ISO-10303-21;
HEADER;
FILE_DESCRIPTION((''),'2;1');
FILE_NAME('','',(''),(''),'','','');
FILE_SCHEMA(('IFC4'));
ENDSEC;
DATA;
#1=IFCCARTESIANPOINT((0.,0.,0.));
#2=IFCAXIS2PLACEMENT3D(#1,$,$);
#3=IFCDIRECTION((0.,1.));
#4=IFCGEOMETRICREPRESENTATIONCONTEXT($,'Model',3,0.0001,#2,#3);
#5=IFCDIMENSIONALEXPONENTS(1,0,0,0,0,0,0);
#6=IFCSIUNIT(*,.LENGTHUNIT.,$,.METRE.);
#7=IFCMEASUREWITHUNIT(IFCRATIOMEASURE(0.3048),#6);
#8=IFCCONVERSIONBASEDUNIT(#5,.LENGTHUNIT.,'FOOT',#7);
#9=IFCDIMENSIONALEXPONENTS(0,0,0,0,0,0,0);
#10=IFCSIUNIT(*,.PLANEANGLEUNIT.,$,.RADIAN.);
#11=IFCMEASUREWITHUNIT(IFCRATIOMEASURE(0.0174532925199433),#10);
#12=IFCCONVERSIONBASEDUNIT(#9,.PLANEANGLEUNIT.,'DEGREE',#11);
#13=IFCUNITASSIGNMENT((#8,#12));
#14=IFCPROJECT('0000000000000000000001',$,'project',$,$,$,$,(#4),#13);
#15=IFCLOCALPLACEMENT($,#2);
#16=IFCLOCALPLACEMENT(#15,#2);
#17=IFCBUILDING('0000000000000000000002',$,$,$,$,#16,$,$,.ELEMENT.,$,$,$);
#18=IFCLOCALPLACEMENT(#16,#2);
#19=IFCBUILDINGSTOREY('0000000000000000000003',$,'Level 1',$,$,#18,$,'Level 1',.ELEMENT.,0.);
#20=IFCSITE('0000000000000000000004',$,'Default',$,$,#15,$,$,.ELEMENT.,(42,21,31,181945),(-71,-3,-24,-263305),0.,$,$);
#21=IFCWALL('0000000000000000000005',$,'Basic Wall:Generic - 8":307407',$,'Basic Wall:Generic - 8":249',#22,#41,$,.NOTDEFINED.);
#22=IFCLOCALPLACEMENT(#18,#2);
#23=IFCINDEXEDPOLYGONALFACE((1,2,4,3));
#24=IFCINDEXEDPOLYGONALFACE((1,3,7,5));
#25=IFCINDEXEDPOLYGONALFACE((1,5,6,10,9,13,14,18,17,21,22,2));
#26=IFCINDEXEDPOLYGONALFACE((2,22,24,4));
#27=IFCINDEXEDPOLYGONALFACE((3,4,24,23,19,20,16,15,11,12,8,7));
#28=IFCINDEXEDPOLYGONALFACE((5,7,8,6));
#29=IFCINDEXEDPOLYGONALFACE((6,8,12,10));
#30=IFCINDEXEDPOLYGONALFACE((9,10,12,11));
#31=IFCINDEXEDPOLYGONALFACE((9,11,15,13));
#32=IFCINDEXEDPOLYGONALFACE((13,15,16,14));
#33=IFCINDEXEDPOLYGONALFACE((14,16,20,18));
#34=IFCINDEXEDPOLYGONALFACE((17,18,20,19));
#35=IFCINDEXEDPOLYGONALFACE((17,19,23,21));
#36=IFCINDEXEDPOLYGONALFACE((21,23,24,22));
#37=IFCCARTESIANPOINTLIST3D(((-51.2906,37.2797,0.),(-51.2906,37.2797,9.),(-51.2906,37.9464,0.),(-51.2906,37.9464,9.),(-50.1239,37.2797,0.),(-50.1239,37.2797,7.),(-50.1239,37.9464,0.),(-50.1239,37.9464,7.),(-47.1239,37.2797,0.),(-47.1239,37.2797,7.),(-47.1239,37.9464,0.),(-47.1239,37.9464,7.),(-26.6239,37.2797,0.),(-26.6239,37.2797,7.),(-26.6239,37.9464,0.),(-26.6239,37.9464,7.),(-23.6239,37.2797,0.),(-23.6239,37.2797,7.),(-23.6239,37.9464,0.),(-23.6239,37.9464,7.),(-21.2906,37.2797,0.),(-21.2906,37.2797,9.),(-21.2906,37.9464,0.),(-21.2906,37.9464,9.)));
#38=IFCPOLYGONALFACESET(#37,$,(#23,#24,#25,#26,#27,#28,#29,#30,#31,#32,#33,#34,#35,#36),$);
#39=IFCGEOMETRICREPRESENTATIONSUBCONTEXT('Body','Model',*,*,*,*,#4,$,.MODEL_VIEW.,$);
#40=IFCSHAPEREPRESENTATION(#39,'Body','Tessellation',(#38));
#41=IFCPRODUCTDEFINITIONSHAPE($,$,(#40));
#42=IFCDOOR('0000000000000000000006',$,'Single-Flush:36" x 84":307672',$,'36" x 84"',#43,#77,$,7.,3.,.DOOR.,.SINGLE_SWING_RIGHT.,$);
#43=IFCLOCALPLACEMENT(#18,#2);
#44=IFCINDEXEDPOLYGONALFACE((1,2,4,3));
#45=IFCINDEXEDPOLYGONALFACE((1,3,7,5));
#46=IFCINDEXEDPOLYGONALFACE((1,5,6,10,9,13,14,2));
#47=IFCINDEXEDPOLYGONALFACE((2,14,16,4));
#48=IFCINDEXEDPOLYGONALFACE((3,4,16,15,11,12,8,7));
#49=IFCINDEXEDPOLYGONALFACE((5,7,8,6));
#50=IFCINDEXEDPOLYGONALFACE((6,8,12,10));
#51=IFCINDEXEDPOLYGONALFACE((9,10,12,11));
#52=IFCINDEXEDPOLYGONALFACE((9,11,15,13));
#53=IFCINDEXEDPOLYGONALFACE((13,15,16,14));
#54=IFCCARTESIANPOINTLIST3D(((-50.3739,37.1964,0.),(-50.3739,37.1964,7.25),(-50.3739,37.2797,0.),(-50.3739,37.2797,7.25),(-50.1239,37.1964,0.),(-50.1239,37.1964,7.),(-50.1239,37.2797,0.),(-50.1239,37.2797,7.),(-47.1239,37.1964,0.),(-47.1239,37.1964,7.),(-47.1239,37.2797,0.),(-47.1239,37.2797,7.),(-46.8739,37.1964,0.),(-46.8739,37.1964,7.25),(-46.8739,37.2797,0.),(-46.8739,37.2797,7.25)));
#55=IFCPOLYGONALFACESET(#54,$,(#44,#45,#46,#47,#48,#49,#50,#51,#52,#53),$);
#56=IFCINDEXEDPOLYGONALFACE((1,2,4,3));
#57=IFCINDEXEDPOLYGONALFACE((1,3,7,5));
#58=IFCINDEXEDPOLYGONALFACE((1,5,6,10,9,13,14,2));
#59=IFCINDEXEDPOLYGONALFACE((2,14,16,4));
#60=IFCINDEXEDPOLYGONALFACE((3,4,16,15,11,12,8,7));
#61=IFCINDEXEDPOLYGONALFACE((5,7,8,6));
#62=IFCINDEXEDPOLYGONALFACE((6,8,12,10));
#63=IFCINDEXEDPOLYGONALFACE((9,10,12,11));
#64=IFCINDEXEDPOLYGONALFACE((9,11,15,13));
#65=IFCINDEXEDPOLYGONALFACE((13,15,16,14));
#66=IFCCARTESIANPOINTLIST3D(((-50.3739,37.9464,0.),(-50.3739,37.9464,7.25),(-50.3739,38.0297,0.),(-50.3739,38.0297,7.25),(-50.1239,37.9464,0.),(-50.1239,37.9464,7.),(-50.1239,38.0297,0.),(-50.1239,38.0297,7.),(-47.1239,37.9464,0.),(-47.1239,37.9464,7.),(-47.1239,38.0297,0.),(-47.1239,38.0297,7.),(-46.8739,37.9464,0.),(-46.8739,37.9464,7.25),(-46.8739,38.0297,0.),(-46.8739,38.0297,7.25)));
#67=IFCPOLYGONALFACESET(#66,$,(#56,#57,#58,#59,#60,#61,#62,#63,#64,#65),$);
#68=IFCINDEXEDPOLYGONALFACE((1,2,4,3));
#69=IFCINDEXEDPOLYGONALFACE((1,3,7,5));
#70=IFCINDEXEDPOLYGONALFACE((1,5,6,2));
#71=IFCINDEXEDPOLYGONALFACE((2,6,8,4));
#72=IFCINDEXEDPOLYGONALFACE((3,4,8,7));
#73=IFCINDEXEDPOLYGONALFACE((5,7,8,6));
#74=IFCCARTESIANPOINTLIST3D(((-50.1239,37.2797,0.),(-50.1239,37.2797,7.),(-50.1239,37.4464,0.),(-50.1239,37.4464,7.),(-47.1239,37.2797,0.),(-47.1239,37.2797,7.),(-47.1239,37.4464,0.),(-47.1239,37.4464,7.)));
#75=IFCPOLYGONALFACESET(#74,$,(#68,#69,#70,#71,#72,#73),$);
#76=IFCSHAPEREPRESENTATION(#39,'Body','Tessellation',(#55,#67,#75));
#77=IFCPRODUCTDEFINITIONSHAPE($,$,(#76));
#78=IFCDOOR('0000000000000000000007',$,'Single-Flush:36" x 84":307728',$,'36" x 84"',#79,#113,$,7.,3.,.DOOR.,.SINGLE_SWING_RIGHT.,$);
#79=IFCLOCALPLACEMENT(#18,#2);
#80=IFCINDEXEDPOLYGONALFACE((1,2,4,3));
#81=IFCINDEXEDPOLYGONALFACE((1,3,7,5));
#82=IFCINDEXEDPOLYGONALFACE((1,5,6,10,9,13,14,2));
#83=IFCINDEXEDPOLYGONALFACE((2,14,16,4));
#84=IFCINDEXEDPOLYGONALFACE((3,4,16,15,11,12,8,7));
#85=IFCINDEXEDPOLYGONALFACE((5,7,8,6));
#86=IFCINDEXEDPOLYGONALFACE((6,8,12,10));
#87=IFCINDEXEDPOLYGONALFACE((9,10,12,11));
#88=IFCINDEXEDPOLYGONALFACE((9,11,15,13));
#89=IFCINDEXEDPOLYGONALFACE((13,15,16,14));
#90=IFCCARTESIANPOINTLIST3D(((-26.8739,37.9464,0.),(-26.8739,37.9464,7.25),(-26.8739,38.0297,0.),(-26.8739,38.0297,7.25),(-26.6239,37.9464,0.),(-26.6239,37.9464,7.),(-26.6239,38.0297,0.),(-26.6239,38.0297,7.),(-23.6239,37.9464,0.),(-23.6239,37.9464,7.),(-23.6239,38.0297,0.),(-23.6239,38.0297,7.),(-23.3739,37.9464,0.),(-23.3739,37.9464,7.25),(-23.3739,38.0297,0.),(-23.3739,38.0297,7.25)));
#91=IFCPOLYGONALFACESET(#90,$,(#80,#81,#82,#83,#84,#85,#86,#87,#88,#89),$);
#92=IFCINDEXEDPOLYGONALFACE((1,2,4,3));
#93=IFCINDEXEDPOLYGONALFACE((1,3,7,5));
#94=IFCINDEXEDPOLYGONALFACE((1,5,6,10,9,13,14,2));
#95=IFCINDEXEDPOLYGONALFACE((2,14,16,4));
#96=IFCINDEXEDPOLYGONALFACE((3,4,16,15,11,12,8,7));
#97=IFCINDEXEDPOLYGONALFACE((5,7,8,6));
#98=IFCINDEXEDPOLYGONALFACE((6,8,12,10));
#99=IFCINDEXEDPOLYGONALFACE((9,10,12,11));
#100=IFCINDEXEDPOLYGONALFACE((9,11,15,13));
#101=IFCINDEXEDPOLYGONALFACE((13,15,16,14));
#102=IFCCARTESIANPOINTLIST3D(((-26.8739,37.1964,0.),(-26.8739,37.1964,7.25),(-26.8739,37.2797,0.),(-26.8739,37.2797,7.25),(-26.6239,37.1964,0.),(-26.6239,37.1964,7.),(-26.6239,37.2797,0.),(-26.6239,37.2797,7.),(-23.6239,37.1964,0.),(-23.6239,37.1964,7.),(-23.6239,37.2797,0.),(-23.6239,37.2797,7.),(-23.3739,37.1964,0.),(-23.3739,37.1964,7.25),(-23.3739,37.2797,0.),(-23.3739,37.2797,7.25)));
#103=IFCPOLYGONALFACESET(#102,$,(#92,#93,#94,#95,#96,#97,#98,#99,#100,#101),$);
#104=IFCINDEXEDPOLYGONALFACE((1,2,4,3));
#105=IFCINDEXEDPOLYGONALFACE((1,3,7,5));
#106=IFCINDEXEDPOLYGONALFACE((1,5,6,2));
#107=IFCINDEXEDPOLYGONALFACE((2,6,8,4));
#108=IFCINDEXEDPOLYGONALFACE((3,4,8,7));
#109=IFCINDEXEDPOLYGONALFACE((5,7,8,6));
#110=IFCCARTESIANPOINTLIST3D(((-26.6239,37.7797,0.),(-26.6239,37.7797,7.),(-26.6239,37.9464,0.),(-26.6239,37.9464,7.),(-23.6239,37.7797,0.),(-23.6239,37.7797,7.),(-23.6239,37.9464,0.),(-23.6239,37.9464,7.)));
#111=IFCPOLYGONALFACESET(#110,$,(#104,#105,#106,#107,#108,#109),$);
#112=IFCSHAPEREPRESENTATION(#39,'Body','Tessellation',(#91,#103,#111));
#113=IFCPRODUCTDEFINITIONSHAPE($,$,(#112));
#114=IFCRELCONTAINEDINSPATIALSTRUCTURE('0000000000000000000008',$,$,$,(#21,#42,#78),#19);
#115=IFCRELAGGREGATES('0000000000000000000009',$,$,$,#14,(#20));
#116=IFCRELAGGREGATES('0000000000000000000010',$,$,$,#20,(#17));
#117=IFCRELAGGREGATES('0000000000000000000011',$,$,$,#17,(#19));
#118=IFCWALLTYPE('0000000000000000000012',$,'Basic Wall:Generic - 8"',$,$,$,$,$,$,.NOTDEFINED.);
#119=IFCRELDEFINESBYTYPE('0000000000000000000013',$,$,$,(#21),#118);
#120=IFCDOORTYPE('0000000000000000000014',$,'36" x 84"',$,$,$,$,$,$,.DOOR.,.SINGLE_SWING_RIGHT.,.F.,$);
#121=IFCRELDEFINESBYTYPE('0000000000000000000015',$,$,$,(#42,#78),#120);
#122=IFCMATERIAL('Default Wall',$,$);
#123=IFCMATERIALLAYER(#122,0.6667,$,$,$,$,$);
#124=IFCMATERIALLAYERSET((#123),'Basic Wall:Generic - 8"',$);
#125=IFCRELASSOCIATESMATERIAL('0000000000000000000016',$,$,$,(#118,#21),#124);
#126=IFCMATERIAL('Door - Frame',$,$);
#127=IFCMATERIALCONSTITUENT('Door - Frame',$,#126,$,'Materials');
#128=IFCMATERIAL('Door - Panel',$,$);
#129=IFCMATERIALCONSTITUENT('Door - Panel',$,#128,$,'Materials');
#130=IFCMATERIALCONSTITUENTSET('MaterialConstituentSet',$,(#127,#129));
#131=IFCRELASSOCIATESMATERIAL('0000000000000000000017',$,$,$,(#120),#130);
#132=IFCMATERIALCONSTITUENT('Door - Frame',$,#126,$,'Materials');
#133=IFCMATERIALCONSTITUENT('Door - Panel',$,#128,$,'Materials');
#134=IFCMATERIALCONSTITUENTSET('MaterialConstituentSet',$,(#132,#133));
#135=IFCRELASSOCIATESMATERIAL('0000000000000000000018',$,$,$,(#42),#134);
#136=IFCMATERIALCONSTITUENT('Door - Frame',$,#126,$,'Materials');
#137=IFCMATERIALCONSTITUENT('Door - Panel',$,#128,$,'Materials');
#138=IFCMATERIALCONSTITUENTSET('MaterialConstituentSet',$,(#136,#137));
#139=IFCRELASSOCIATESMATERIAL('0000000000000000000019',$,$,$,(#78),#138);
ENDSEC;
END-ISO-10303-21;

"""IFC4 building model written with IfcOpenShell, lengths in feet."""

from ifc_helpers import new_model, entity, si_unit, converted_unit, direction, frame, frame_2d, origin, place, context, subcontext, project, spatial, polyline, rectangle, outline, extrude, clip, bounded_halfspace, source, transform, mapped, material, layer, layer_set, layer_usage, constituent, constituent_set, type_object, type_shapes, element, fill, save


model = new_model("IFC4")

# Units and contexts
model_context = context("Model", 3, precision=0.0001, world=origin(), true_north=direction((0.0, 1.0)))
body_context = subcontext(model_context, "Body", "Model", "MODEL_VIEW")
ifc_project = project(units=[converted_unit("LENGTHUNIT", "FOOT", entity("IfcRatioMeasure", 0.3048), si_unit("LENGTHUNIT", "METRE"), dimensions=[1, 0, 0, 0, 0, 0, 0]), converted_unit("PLANEANGLEUNIT", "DEGREE", entity("IfcRatioMeasure", 0.0174532925199433), si_unit("PLANEANGLEUNIT", "RADIAN"), dimensions=[0, 0, 0, 0, 0, 0, 0])], contexts=[model_context])

# Site, building, storey
site_placement = place(None, origin())
site = spatial("IfcSite", under=ifc_project, at=site_placement, Name="Default", CompositionType="ELEMENT", RefLatitude=(42, 21, 31, 181945), RefLongitude=(-71, -3, -24, -263305), RefElevation=0.0)
building_placement = place(site_placement, origin())
building = spatial("IfcBuilding", under=site, at=building_placement, CompositionType="ELEMENT")
storey_placement = place(building_placement, origin())
storey = spatial("IfcBuildingStorey", under=building, at=storey_placement, Name="Level 1", LongName="Level 1", CompositionType="ELEMENT", Elevation=0.0)

# Shared definitions
ifc_material_1 = material(Name="Default Wall")
ifc_layer = layer(ifc_material_1, 0.6667)
ifc_layer_set = layer_set([ifc_layer], Name="Basic Wall:Generic - 8\"")
wall_type = type_object("IfcWallType", Name="Basic Wall:Generic - 8\"", PredefinedType="NOTDEFINED", material=ifc_layer_set)
ifc_material_2 = material(Name="Door - Frame")
ifc_material_3 = material(Name="Door - Panel")
ifc_constituent_1 = constituent(ifc_material_2, Name="Door - Frame", Category="Materials")
ifc_constituent_2 = constituent(ifc_material_3, Name="Door - Panel", Category="Materials")
ifc_constituent_set_1 = constituent_set(constituents=[ifc_constituent_1, ifc_constituent_2], Name="MaterialConstituentSet")
door_type = type_object("IfcDoorType", Name="36\" x 84\"", OperationType="SINGLE_SWING_RIGHT", ParameterTakesPrecedence=False, PredefinedType="DOOR", material=ifc_constituent_set_1)
shared_shape_1 = source(origin(), body_context, "Body", "SweptSolid", [
    extrude(outline(polyline([(-1.75, -3.6875), (1.75, -3.6875), (1.75, 3.5625), (1.5, 3.5625), (1.5, -3.4375), (-1.5, -3.4375), (-1.5, 3.5625), (-1.75, 3.5625), (-1.75, -3.6875)])), frame((1.5, 0.6667, 3.5625), z_axis=(0.0, 1.0, 0.0), x_axis=(1.0, 0.0, 0.0)), (0.0, 0.0, 1.0), 0.0833),
    extrude(outline(polyline([(-3.6875, -1.75), (3.5625, -1.75), (3.5625, -1.5), (-3.4375, -1.5), (-3.4375, 1.5), (3.5625, 1.5), (3.5625, 1.75), (-3.6875, 1.75), (-3.6875, -1.75)])), frame((1.5, -0.0833, 3.5625), z_axis=(0.0, 1.0, 0.0), x_axis=(0.0, 0.0, -1.0)), (0.0, 0.0, 1.0), 0.0833),
    extrude(rectangle(XDim=0.1667, YDim=3.0, at=frame_2d((0.0, 0.0), x_axis=(1.0, 0.0))), frame((1.5, 0.5833, 0.0), z_axis=(0.0, 0.0, 1.0), x_axis=(0.0, 1.0, 0.0)), (0.0, 0.0, 1.0), 7.0),
])
type_shapes(door_type, [shared_shape_1])

# Wall, openings, doors
ifc_layer_usage_1 = layer_usage(ifc_layer_set, "AXIS2", "NEGATIVE", 0.3333)
wall_1_placement = place(storey_placement, frame((-21.2906, 37.6131, 0.0), z_axis=(0.0, 0.0, 1.0), x_axis=(-1.0, 0.0, 0.0)))
wall_1 = element("IfcWall", 1, at=wall_1_placement, inside=storey, type_object=wall_type, material=ifc_layer_usage_1, Name="Basic Wall:Generic - 8\":307407", ObjectType="Basic Wall:Generic - 8\":249", PredefinedType="NOTDEFINED", context=body_context, shape_type="Clipping", body=[
    clip(extrude(rectangle(XDim=30.0, YDim=0.6667, at=frame_2d((15.0, 0.0), x_axis=(-1.0, 0.0))), origin(), (0.0, 0.0, 1.0), 9.0), bounded_halfspace(frame((0.0, -0.3333, 9.0), z_axis=(0.0, 0.0, -1.0), x_axis=(-1.0, 0.0, 0.0)), True, frame((0.0, -0.3333, 9.0)), polyline([(0.0, 0.0), (30.0, 0.0), (30.0, 0.6667), (0.6667, 0.6667), (0.0, 0.6667), (0.0, 0.0)]))),
])
opening_1_placement = place(wall_1_placement, frame((25.8333, -0.3333, 0.0)))
opening_1 = element("IfcOpeningElement", 2, at=opening_1_placement, cuts=wall_1, ObjectType="Opening", PredefinedType="OPENING", context=body_context, shape_type="SweptSolid", body=[
    extrude(rectangle(XDim=3.0, YDim=7.0, at=frame_2d((3.5, 1.5), x_axis=(0.0, 1.0))), frame((0.0, 0.0, 0.0), z_axis=(0.0, 1.0, 0.0), x_axis=(0.0, 0.0, 1.0)), (0.0, 0.0, 1.0), 0.6667),
])
opening_2_placement = place(wall_1_placement, frame((5.3333, 0.3333, 0.0)))
opening_2 = element("IfcOpeningElement", 3, at=opening_2_placement, cuts=wall_1, ObjectType="Opening", PredefinedType="OPENING", context=body_context, shape_type="SweptSolid", body=[
    extrude(rectangle(XDim=3.0, YDim=7.0, at=frame_2d((3.5, 1.5), x_axis=(0.0, 1.0))), frame((0.0, 0.0, 0.0), z_axis=(0.0, -1.0, 0.0), x_axis=(0.0, 0.0, 1.0)), (0.0, 0.0, 1.0), 0.6667),
])
ifc_constituent_3 = constituent(ifc_material_2, Name="Door - Frame", Category="Materials")
ifc_constituent_4 = constituent(ifc_material_3, Name="Door - Panel", Category="Materials")
ifc_constituent_set_2 = constituent_set(constituents=[ifc_constituent_3, ifc_constituent_4], Name="MaterialConstituentSet")
door_1_placement = place(opening_1_placement, origin())
door_1 = element("IfcDoor", 4, at=door_1_placement, inside=storey, type_object=door_type, material=ifc_constituent_set_2, Name="Single-Flush:36\" x 84\":307672", ObjectType="36\" x 84\"", OperationType="SINGLE_SWING_RIGHT", OverallHeight=7.0, OverallWidth=3.0, PredefinedType="DOOR", context=body_context, shape_type="MappedRepresentation", body=[
    mapped(shared_shape_1, transform((0.0, 0.0, 0.0), scale=1.0)),
])
fill(opening_1, door_1)
ifc_constituent_5 = constituent(ifc_material_2, Name="Door - Frame", Category="Materials")
ifc_constituent_6 = constituent(ifc_material_3, Name="Door - Panel", Category="Materials")
ifc_constituent_set_3 = constituent_set(constituents=[ifc_constituent_5, ifc_constituent_6], Name="MaterialConstituentSet")
door_2_placement = place(opening_2_placement, frame((0.0, 0.0, 0.0), z_axis=(0.0, 0.0, 1.0), x_axis=(-1.0, 0.0, 0.0)))
door_2 = element("IfcDoor", 5, at=door_2_placement, inside=storey, type_object=door_type, material=ifc_constituent_set_3, Name="Single-Flush:36\" x 84\":307728", ObjectType="36\" x 84\"", OperationType="SINGLE_SWING_RIGHT", OverallHeight=7.0, OverallWidth=3.0, PredefinedType="DOOR", context=body_context, shape_type="MappedRepresentation", body=[
    mapped(shared_shape_1, transform((0.0, 0.0, 0.0), scale=1.0)),
])
fill(opening_2, door_2)

save(model, "model.ifc")
